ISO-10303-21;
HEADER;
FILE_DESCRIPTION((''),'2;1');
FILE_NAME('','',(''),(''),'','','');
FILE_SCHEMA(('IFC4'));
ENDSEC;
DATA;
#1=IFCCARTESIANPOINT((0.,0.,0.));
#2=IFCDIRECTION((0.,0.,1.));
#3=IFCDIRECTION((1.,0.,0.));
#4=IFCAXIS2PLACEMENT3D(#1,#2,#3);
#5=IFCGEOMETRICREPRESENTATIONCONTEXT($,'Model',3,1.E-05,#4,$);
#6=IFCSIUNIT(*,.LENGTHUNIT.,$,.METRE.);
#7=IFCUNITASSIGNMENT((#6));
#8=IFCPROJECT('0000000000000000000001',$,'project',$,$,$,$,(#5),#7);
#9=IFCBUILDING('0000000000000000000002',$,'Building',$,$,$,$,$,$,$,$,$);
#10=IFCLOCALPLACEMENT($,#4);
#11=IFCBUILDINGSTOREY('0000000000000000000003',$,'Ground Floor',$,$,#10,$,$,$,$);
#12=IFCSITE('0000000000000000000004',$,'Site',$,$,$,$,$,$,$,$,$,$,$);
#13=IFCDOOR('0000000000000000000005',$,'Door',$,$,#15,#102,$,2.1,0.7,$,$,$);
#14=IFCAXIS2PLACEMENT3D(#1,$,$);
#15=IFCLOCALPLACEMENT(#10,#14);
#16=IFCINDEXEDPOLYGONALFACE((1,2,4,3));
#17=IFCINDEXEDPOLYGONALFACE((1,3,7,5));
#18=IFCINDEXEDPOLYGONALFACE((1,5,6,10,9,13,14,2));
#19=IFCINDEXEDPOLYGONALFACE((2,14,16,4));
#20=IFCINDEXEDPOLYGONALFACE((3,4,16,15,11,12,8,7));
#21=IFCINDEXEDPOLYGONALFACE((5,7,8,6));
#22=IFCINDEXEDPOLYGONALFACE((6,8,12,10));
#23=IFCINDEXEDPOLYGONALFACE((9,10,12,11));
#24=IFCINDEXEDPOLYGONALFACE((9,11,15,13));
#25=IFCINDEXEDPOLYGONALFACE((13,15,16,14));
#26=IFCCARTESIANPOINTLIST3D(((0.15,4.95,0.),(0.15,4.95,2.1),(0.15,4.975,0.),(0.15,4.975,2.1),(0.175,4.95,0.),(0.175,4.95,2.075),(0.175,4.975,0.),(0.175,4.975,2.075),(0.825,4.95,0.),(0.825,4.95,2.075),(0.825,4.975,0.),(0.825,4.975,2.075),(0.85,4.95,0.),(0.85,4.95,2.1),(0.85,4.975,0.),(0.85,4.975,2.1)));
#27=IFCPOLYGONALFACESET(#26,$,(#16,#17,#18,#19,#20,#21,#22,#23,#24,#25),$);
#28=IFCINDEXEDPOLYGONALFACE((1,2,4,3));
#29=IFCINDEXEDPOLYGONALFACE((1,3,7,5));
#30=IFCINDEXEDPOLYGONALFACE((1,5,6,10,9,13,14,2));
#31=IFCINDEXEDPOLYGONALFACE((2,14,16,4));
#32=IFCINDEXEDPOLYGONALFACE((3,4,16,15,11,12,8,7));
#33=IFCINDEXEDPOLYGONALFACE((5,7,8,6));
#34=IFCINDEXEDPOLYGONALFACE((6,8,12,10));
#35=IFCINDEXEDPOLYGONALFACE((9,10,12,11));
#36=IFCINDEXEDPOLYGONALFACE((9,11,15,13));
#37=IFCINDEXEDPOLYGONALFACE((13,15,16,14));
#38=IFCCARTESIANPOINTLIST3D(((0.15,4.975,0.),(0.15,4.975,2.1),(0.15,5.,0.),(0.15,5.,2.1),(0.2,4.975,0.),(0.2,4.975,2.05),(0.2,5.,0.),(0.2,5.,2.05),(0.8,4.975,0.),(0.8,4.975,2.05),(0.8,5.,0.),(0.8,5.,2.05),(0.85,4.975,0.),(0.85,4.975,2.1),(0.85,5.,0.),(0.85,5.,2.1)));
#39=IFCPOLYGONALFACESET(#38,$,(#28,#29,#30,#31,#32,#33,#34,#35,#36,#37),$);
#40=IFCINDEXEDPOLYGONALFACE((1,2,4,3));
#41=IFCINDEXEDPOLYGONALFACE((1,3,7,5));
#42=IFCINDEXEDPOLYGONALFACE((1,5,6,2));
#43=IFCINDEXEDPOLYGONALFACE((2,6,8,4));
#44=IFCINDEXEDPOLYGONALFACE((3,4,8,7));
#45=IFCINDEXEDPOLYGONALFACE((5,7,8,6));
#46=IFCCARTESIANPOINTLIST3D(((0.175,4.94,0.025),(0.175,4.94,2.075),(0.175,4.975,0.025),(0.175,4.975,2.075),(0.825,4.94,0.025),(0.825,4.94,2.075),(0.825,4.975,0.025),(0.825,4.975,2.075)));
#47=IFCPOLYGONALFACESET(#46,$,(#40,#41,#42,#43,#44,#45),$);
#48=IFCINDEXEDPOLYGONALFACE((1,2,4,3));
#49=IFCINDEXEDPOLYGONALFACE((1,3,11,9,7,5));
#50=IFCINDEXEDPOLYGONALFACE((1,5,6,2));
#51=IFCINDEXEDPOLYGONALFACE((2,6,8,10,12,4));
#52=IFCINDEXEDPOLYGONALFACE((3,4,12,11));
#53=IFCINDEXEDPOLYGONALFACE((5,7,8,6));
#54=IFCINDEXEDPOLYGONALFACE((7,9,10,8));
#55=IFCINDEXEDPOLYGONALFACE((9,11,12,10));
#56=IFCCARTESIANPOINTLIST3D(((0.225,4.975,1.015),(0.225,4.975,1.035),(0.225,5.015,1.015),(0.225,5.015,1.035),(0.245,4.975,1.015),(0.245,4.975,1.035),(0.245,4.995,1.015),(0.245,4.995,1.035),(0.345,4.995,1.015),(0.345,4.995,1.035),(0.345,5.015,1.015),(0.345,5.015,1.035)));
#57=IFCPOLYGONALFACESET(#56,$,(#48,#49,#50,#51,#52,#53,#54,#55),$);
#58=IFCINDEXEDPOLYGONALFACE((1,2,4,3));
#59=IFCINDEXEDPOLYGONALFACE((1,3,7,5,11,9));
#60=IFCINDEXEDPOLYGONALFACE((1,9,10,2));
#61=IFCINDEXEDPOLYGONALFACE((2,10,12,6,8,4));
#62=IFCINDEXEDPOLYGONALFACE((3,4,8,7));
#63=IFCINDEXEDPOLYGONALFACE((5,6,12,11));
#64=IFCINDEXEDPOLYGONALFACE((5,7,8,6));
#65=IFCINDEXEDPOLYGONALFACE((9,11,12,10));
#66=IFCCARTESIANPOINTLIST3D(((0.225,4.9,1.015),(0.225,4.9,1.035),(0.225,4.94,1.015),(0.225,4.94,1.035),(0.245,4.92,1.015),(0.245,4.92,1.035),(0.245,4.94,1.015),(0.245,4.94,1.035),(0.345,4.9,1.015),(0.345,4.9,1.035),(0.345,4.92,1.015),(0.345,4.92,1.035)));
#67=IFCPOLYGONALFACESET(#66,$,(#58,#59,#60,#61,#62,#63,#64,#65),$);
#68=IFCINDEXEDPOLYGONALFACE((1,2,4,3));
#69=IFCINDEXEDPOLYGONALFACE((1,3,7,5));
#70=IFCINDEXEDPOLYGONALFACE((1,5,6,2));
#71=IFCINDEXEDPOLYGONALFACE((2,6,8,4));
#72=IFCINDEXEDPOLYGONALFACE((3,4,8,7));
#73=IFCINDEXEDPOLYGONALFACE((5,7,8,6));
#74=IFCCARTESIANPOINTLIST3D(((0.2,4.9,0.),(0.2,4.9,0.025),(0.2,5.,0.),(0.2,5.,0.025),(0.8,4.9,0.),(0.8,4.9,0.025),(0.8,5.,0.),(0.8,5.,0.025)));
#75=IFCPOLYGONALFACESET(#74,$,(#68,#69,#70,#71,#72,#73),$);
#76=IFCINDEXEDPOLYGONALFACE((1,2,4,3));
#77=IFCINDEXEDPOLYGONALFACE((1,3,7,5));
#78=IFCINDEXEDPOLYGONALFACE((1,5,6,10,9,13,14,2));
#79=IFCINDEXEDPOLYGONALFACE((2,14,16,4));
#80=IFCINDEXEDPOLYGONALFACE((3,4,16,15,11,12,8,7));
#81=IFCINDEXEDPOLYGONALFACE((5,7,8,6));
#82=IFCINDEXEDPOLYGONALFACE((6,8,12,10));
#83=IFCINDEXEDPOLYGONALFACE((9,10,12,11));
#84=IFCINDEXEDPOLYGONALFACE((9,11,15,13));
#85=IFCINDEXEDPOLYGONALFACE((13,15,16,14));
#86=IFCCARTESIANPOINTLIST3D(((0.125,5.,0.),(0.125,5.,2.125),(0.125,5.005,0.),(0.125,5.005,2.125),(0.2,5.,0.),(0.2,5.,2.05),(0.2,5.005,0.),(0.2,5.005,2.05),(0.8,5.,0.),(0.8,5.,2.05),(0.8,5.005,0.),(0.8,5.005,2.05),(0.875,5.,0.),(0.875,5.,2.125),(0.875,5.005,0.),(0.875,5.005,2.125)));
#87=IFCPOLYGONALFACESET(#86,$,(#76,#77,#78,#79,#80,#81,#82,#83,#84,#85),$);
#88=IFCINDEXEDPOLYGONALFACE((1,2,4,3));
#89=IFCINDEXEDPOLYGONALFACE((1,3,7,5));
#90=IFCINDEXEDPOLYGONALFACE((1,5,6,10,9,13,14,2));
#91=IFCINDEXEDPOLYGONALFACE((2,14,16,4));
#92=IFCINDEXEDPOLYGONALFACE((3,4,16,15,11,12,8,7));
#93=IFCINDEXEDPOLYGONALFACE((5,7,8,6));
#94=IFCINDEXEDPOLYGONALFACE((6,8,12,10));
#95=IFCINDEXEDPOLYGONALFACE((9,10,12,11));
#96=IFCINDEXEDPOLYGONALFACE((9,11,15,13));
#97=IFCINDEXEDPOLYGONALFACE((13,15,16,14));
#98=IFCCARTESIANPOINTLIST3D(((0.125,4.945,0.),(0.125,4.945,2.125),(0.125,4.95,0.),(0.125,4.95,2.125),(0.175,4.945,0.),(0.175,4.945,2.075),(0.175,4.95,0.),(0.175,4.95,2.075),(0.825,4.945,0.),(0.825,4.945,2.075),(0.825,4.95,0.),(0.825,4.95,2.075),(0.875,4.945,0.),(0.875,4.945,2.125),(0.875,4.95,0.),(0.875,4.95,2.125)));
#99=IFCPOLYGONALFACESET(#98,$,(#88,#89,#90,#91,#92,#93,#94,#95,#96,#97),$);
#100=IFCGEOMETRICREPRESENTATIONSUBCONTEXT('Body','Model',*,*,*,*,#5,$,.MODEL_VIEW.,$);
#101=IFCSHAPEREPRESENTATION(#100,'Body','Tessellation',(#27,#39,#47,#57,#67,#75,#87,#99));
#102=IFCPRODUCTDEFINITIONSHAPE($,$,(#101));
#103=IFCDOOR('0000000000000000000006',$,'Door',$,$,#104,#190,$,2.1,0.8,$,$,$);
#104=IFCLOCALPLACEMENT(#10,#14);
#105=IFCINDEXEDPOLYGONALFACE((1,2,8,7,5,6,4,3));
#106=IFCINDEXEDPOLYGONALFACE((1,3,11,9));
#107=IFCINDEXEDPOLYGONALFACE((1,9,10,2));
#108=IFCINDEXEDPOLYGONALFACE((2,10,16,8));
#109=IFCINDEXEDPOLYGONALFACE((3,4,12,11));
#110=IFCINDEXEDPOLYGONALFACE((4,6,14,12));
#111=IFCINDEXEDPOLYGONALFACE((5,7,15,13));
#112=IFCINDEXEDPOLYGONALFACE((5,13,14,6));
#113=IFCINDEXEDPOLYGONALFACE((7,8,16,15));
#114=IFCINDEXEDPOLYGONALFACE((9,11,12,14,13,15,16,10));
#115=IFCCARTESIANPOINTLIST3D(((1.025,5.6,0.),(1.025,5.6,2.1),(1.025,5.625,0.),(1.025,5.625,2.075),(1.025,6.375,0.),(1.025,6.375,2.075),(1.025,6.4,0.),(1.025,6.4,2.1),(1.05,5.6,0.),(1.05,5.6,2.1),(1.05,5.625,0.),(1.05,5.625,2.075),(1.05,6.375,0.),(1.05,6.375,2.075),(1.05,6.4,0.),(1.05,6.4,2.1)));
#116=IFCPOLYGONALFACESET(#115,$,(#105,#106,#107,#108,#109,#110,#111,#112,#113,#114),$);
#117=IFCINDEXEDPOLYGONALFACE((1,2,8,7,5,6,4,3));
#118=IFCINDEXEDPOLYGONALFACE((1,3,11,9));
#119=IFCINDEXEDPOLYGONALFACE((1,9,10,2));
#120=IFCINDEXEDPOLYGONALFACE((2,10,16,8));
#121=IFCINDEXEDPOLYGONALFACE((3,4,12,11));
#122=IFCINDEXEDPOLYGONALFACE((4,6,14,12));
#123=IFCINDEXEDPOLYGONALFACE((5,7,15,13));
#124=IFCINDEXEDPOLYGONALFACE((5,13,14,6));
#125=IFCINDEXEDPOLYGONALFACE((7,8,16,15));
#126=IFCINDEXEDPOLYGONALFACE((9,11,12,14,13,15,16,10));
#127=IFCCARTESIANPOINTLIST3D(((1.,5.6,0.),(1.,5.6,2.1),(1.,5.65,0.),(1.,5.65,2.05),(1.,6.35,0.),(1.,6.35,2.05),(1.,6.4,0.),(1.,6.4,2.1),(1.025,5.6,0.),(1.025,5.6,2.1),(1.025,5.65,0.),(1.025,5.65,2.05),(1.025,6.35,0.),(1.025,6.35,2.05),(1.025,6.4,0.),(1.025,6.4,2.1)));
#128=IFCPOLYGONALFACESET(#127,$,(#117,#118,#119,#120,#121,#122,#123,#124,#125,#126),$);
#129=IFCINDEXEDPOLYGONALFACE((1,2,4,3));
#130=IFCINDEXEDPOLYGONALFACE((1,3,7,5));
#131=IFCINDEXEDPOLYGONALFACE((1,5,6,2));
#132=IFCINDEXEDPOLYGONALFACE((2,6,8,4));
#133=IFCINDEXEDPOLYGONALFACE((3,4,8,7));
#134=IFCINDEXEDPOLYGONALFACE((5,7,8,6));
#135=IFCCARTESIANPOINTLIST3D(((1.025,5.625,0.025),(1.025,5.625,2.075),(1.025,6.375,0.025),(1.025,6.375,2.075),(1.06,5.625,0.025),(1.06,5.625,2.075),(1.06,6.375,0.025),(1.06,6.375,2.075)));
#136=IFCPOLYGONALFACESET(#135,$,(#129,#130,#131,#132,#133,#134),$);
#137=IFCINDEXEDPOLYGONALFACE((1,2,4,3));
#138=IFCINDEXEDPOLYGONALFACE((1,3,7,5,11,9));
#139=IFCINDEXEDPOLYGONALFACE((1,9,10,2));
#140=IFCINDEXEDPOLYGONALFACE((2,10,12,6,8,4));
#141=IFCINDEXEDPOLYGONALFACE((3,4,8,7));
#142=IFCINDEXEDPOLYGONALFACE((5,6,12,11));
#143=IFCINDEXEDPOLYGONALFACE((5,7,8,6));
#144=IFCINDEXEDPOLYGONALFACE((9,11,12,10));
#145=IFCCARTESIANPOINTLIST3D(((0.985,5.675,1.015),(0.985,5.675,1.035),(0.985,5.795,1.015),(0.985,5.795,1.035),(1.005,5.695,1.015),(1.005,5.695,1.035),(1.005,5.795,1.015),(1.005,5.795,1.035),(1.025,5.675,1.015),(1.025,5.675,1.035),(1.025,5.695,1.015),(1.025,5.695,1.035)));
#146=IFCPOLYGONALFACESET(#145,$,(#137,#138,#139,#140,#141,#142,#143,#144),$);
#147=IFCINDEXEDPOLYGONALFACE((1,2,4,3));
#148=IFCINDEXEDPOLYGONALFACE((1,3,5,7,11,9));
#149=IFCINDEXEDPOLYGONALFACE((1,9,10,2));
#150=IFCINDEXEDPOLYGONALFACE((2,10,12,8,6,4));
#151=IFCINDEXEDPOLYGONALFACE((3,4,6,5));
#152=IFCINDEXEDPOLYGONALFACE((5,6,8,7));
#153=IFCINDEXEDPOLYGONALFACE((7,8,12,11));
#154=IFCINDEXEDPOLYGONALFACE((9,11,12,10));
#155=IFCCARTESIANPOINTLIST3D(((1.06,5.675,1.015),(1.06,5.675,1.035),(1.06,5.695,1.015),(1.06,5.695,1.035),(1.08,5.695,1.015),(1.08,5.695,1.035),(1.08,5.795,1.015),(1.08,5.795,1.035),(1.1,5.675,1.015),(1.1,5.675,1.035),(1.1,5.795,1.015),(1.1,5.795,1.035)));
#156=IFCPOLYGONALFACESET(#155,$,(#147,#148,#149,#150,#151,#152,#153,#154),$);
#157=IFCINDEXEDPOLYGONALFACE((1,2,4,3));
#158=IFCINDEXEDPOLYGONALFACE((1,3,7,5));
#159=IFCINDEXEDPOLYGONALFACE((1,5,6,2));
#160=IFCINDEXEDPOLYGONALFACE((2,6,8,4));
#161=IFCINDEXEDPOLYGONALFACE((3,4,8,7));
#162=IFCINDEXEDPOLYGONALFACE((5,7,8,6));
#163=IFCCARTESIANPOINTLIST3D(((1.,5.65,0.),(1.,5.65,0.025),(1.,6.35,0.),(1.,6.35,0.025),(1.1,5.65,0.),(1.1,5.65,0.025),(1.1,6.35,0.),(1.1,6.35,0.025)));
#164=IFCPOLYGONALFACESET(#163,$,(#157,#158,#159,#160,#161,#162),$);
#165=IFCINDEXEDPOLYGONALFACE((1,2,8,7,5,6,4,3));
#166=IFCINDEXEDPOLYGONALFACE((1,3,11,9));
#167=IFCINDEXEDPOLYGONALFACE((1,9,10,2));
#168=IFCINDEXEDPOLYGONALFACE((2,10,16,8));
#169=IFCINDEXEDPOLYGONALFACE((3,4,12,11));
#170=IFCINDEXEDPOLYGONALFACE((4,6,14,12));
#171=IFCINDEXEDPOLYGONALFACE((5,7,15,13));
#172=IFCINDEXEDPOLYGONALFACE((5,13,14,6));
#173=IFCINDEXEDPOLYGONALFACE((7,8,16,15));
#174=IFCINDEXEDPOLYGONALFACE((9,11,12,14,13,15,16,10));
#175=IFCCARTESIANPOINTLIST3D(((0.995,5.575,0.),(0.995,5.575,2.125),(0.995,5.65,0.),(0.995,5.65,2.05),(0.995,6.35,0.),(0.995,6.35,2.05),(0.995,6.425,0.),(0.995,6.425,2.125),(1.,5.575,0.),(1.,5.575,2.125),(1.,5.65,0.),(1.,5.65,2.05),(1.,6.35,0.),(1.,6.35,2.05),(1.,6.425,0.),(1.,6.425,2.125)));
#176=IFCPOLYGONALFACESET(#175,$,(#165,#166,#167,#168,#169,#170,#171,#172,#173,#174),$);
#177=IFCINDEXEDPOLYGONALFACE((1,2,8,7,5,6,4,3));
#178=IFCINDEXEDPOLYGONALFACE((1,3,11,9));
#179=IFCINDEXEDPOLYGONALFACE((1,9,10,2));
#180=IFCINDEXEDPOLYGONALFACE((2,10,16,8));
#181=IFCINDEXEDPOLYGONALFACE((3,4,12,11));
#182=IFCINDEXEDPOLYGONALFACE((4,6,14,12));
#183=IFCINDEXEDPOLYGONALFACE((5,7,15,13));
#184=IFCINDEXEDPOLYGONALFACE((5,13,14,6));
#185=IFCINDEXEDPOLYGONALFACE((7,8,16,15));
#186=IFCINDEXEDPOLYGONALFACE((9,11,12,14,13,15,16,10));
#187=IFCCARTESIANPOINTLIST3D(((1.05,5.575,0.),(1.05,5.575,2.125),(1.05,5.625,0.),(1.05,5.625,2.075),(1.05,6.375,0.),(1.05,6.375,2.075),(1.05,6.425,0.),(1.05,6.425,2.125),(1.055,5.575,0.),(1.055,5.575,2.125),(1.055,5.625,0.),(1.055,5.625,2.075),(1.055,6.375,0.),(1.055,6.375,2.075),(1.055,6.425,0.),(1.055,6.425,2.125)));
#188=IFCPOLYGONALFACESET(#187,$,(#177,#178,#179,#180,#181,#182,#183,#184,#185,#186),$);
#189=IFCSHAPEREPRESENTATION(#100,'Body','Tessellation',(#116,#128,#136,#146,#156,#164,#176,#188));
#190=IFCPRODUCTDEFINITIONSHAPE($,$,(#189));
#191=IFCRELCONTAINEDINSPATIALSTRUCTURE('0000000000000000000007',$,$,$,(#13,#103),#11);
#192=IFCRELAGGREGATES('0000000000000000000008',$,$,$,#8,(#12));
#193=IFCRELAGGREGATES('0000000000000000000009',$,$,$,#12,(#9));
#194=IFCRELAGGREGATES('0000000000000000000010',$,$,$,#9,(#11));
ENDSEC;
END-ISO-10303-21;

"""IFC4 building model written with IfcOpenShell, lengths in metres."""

from ifc_helpers import new_model, si_unit, frame, origin_with_axes, place, context, subcontext, project, spatial, line, indexed_curve, outline, extrude, element, save


model = new_model("IFC4")

# Units and contexts
model_context = context("Model", 3, precision=1e-05, world=origin_with_axes())
body_context = subcontext(model_context, "Body", "Model", "MODEL_VIEW")
ifc_project = project(units=[si_unit("LENGTHUNIT", "METRE")], contexts=[model_context])

# Site, building, storey
site = spatial("IfcSite", under=ifc_project, Name="Site")
building = spatial("IfcBuilding", under=site, Name="Building")
storey_placement = place(None, origin_with_axes())
storey = spatial("IfcBuildingStorey", under=building, at=storey_placement, Name="Ground Floor")

# Doors
door_1_placement = place(storey_placement, frame((0.85, 5.0, 0.0), z_axis=(0.0, 0.0, 1.0), x_axis=(-1.0, 0.0, 0.0)))
element("IfcDoor", 1, at=door_1_placement, inside=storey, Name="Door", OverallHeight=2.1, OverallWidth=0.7, context=body_context, shape_type="SweptSolid", body=[
    extrude(outline(indexed_curve([(0.0, 0.0), (0.0, 2.1), (0.7, 2.1), (0.7, 0.0), (0.675, 0.0), (0.675, 2.075), (0.025, 2.075), (0.025, 0.0)], segments=[line(1, 2, 3, 4, 5, 6, 7, 8, 1)])), frame((0.0, 0.025, 0.0), z_axis=(0.0, -1.0, 0.0), x_axis=(1.0, 0.0, 0.0)), (0.0, 0.0, -1.0), 0.025),
    extrude(outline(indexed_curve([(0.0, 0.0), (0.0, 2.1), (0.7, 2.1), (0.7, 0.0), (0.65, 0.0), (0.65, 2.05), (0.05, 2.05), (0.05, 0.0)], segments=[line(1, 2, 3, 4, 5, 6, 7, 8, 1)])), frame((0.0, 0.0, 0.0), z_axis=(0.0, -1.0, 0.0), x_axis=(1.0, 0.0, 0.0)), (0.0, 0.0, -1.0), 0.025),
    extrude(outline(indexed_curve([(0.0, 0.0), (0.65, 0.0), (0.65, 0.035), (0.0, 0.035)], segments=[line(1, 2, 3, 4, 1)])), frame((0.025, 0.025, 0.025), z_axis=(0.0, 0.0, 1.0), x_axis=(1.0, 0.0, 0.0)), (0.0, 0.0, 1.0), 2.05),
    extrude(outline(indexed_curve([(0.0, 0.0), (0.0, -0.04), (-0.12, -0.04), (-0.12, -0.02), (-0.02, -0.02), (-0.02, 0.0)], segments=[line(1, 2, 3, 4, 5, 6, 1)])), frame((0.625, 0.025, 1.015), z_axis=(0.0, 0.0, 1.0), x_axis=(1.0, 0.0, 0.0)), (0.0, 0.0, 1.0), 0.02),
    extrude(outline(indexed_curve([(0.0, 0.0), (0.0, 0.04), (-0.12, 0.04), (-0.12, 0.02), (-0.02, 0.02), (-0.02, 0.0)], segments=[line(1, 2, 3, 4, 5, 6, 1)])), frame((0.625, 0.06, 1.015), z_axis=(0.0, 0.0, 1.0), x_axis=(1.0, 0.0, 0.0)), (0.0, 0.0, 1.0), 0.02),
    extrude(outline(indexed_curve([(0.0, 0.0), (0.6, 0.0), (0.6, 0.1), (0.0, 0.1)], segments=[line(1, 2, 3, 4, 1)])), frame((0.05, 0.0, 0.0), z_axis=(0.0, 0.0, 1.0), x_axis=(1.0, 0.0, 0.0)), (0.0, 0.0, 1.0), 0.025),
    extrude(outline(indexed_curve([(0.0, 0.0), (0.0, 2.125), (0.75, 2.125), (0.75, 0.0), (0.675, 0.0), (0.675, 2.05), (0.075, 2.05), (0.075, 0.0)], segments=[line(1, 2, 3, 4, 5, 6, 7, 8, 1)])), frame((-0.025, -0.005, 0.0), z_axis=(0.0, -1.0, 0.0), x_axis=(1.0, 0.0, 0.0)), (0.0, 0.0, -1.0), 0.005),
    extrude(outline(indexed_curve([(0.0, 0.0), (0.0, 2.125), (0.75, 2.125), (0.75, 0.0), (0.7, 0.0), (0.7, 2.075), (0.05, 2.075), (0.05, 0.0)], segments=[line(1, 2, 3, 4, 5, 6, 7, 8, 1)])), frame((-0.025, 0.05, 0.0), z_axis=(0.0, -1.0, 0.0), x_axis=(1.0, 0.0, 0.0)), (0.0, 0.0, -1.0), 0.005),
])
door_2_placement = place(storey_placement, frame((1.0, 6.4, 0.0), z_axis=(0.0, 0.0, 1.0), x_axis=(0.0, -1.0, 0.0)))
element("IfcDoor", 2, at=door_2_placement, inside=storey, Name="Door", OverallHeight=2.1, OverallWidth=0.8, context=body_context, shape_type="SweptSolid", body=[
    extrude(outline(indexed_curve([(0.0, 0.0), (0.0, 2.1), (0.8, 2.1), (0.8, 0.0), (0.775, 0.0), (0.775, 2.075), (0.025, 2.075), (0.025, 0.0)], segments=[line(1, 2, 3, 4, 5, 6, 7, 8, 1)])), frame((0.0, 0.025, 0.0), z_axis=(0.0, -1.0, 0.0), x_axis=(1.0, 0.0, 0.0)), (0.0, 0.0, -1.0), 0.025),
    extrude(outline(indexed_curve([(0.0, 0.0), (0.0, 2.1), (0.8, 2.1), (0.8, 0.0), (0.75, 0.0), (0.75, 2.05), (0.05, 2.05), (0.05, 0.0)], segments=[line(1, 2, 3, 4, 5, 6, 7, 8, 1)])), frame((0.0, 0.0, 0.0), z_axis=(0.0, -1.0, 0.0), x_axis=(1.0, 0.0, 0.0)), (0.0, 0.0, -1.0), 0.025),
    extrude(outline(indexed_curve([(0.0, 0.0), (0.75, 0.0), (0.75, 0.035), (0.0, 0.035)], segments=[line(1, 2, 3, 4, 1)])), frame((0.025, 0.025, 0.025), z_axis=(0.0, 0.0, 1.0), x_axis=(1.0, 0.0, 0.0)), (0.0, 0.0, 1.0), 2.05),
    extrude(outline(indexed_curve([(0.0, 0.0), (0.0, -0.04), (-0.12, -0.04), (-0.12, -0.02), (-0.02, -0.02), (-0.02, 0.0)], segments=[line(1, 2, 3, 4, 5, 6, 1)])), frame((0.725, 0.025, 1.015), z_axis=(0.0, 0.0, 1.0), x_axis=(1.0, 0.0, 0.0)), (0.0, 0.0, 1.0), 0.02),
    extrude(outline(indexed_curve([(0.0, 0.0), (0.0, 0.04), (-0.12, 0.04), (-0.12, 0.02), (-0.02, 0.02), (-0.02, 0.0)], segments=[line(1, 2, 3, 4, 5, 6, 1)])), frame((0.725, 0.06, 1.015), z_axis=(0.0, 0.0, 1.0), x_axis=(1.0, 0.0, 0.0)), (0.0, 0.0, 1.0), 0.02),
    extrude(outline(indexed_curve([(0.0, 0.0), (0.7, 0.0), (0.7, 0.1), (0.0, 0.1)], segments=[line(1, 2, 3, 4, 1)])), frame((0.05, 0.0, 0.0), z_axis=(0.0, 0.0, 1.0), x_axis=(1.0, 0.0, 0.0)), (0.0, 0.0, 1.0), 0.025),
    extrude(outline(indexed_curve([(0.0, 0.0), (0.0, 2.125), (0.85, 2.125), (0.85, 0.0), (0.775, 0.0), (0.775, 2.05), (0.075, 2.05), (0.075, 0.0)], segments=[line(1, 2, 3, 4, 5, 6, 7, 8, 1)])), frame((-0.025, -0.005, 0.0), z_axis=(0.0, -1.0, 0.0), x_axis=(1.0, 0.0, 0.0)), (0.0, 0.0, -1.0), 0.005),
    extrude(outline(indexed_curve([(0.0, 0.0), (0.0, 2.125), (0.85, 2.125), (0.85, 0.0), (0.8, 0.0), (0.8, 2.075), (0.05, 2.075), (0.05, 0.0)], segments=[line(1, 2, 3, 4, 5, 6, 7, 8, 1)])), frame((-0.025, 0.05, 0.0), z_axis=(0.0, -1.0, 0.0), x_axis=(1.0, 0.0, 0.0)), (0.0, 0.0, -1.0), 0.005),
])

save(model, "model.ifc")
